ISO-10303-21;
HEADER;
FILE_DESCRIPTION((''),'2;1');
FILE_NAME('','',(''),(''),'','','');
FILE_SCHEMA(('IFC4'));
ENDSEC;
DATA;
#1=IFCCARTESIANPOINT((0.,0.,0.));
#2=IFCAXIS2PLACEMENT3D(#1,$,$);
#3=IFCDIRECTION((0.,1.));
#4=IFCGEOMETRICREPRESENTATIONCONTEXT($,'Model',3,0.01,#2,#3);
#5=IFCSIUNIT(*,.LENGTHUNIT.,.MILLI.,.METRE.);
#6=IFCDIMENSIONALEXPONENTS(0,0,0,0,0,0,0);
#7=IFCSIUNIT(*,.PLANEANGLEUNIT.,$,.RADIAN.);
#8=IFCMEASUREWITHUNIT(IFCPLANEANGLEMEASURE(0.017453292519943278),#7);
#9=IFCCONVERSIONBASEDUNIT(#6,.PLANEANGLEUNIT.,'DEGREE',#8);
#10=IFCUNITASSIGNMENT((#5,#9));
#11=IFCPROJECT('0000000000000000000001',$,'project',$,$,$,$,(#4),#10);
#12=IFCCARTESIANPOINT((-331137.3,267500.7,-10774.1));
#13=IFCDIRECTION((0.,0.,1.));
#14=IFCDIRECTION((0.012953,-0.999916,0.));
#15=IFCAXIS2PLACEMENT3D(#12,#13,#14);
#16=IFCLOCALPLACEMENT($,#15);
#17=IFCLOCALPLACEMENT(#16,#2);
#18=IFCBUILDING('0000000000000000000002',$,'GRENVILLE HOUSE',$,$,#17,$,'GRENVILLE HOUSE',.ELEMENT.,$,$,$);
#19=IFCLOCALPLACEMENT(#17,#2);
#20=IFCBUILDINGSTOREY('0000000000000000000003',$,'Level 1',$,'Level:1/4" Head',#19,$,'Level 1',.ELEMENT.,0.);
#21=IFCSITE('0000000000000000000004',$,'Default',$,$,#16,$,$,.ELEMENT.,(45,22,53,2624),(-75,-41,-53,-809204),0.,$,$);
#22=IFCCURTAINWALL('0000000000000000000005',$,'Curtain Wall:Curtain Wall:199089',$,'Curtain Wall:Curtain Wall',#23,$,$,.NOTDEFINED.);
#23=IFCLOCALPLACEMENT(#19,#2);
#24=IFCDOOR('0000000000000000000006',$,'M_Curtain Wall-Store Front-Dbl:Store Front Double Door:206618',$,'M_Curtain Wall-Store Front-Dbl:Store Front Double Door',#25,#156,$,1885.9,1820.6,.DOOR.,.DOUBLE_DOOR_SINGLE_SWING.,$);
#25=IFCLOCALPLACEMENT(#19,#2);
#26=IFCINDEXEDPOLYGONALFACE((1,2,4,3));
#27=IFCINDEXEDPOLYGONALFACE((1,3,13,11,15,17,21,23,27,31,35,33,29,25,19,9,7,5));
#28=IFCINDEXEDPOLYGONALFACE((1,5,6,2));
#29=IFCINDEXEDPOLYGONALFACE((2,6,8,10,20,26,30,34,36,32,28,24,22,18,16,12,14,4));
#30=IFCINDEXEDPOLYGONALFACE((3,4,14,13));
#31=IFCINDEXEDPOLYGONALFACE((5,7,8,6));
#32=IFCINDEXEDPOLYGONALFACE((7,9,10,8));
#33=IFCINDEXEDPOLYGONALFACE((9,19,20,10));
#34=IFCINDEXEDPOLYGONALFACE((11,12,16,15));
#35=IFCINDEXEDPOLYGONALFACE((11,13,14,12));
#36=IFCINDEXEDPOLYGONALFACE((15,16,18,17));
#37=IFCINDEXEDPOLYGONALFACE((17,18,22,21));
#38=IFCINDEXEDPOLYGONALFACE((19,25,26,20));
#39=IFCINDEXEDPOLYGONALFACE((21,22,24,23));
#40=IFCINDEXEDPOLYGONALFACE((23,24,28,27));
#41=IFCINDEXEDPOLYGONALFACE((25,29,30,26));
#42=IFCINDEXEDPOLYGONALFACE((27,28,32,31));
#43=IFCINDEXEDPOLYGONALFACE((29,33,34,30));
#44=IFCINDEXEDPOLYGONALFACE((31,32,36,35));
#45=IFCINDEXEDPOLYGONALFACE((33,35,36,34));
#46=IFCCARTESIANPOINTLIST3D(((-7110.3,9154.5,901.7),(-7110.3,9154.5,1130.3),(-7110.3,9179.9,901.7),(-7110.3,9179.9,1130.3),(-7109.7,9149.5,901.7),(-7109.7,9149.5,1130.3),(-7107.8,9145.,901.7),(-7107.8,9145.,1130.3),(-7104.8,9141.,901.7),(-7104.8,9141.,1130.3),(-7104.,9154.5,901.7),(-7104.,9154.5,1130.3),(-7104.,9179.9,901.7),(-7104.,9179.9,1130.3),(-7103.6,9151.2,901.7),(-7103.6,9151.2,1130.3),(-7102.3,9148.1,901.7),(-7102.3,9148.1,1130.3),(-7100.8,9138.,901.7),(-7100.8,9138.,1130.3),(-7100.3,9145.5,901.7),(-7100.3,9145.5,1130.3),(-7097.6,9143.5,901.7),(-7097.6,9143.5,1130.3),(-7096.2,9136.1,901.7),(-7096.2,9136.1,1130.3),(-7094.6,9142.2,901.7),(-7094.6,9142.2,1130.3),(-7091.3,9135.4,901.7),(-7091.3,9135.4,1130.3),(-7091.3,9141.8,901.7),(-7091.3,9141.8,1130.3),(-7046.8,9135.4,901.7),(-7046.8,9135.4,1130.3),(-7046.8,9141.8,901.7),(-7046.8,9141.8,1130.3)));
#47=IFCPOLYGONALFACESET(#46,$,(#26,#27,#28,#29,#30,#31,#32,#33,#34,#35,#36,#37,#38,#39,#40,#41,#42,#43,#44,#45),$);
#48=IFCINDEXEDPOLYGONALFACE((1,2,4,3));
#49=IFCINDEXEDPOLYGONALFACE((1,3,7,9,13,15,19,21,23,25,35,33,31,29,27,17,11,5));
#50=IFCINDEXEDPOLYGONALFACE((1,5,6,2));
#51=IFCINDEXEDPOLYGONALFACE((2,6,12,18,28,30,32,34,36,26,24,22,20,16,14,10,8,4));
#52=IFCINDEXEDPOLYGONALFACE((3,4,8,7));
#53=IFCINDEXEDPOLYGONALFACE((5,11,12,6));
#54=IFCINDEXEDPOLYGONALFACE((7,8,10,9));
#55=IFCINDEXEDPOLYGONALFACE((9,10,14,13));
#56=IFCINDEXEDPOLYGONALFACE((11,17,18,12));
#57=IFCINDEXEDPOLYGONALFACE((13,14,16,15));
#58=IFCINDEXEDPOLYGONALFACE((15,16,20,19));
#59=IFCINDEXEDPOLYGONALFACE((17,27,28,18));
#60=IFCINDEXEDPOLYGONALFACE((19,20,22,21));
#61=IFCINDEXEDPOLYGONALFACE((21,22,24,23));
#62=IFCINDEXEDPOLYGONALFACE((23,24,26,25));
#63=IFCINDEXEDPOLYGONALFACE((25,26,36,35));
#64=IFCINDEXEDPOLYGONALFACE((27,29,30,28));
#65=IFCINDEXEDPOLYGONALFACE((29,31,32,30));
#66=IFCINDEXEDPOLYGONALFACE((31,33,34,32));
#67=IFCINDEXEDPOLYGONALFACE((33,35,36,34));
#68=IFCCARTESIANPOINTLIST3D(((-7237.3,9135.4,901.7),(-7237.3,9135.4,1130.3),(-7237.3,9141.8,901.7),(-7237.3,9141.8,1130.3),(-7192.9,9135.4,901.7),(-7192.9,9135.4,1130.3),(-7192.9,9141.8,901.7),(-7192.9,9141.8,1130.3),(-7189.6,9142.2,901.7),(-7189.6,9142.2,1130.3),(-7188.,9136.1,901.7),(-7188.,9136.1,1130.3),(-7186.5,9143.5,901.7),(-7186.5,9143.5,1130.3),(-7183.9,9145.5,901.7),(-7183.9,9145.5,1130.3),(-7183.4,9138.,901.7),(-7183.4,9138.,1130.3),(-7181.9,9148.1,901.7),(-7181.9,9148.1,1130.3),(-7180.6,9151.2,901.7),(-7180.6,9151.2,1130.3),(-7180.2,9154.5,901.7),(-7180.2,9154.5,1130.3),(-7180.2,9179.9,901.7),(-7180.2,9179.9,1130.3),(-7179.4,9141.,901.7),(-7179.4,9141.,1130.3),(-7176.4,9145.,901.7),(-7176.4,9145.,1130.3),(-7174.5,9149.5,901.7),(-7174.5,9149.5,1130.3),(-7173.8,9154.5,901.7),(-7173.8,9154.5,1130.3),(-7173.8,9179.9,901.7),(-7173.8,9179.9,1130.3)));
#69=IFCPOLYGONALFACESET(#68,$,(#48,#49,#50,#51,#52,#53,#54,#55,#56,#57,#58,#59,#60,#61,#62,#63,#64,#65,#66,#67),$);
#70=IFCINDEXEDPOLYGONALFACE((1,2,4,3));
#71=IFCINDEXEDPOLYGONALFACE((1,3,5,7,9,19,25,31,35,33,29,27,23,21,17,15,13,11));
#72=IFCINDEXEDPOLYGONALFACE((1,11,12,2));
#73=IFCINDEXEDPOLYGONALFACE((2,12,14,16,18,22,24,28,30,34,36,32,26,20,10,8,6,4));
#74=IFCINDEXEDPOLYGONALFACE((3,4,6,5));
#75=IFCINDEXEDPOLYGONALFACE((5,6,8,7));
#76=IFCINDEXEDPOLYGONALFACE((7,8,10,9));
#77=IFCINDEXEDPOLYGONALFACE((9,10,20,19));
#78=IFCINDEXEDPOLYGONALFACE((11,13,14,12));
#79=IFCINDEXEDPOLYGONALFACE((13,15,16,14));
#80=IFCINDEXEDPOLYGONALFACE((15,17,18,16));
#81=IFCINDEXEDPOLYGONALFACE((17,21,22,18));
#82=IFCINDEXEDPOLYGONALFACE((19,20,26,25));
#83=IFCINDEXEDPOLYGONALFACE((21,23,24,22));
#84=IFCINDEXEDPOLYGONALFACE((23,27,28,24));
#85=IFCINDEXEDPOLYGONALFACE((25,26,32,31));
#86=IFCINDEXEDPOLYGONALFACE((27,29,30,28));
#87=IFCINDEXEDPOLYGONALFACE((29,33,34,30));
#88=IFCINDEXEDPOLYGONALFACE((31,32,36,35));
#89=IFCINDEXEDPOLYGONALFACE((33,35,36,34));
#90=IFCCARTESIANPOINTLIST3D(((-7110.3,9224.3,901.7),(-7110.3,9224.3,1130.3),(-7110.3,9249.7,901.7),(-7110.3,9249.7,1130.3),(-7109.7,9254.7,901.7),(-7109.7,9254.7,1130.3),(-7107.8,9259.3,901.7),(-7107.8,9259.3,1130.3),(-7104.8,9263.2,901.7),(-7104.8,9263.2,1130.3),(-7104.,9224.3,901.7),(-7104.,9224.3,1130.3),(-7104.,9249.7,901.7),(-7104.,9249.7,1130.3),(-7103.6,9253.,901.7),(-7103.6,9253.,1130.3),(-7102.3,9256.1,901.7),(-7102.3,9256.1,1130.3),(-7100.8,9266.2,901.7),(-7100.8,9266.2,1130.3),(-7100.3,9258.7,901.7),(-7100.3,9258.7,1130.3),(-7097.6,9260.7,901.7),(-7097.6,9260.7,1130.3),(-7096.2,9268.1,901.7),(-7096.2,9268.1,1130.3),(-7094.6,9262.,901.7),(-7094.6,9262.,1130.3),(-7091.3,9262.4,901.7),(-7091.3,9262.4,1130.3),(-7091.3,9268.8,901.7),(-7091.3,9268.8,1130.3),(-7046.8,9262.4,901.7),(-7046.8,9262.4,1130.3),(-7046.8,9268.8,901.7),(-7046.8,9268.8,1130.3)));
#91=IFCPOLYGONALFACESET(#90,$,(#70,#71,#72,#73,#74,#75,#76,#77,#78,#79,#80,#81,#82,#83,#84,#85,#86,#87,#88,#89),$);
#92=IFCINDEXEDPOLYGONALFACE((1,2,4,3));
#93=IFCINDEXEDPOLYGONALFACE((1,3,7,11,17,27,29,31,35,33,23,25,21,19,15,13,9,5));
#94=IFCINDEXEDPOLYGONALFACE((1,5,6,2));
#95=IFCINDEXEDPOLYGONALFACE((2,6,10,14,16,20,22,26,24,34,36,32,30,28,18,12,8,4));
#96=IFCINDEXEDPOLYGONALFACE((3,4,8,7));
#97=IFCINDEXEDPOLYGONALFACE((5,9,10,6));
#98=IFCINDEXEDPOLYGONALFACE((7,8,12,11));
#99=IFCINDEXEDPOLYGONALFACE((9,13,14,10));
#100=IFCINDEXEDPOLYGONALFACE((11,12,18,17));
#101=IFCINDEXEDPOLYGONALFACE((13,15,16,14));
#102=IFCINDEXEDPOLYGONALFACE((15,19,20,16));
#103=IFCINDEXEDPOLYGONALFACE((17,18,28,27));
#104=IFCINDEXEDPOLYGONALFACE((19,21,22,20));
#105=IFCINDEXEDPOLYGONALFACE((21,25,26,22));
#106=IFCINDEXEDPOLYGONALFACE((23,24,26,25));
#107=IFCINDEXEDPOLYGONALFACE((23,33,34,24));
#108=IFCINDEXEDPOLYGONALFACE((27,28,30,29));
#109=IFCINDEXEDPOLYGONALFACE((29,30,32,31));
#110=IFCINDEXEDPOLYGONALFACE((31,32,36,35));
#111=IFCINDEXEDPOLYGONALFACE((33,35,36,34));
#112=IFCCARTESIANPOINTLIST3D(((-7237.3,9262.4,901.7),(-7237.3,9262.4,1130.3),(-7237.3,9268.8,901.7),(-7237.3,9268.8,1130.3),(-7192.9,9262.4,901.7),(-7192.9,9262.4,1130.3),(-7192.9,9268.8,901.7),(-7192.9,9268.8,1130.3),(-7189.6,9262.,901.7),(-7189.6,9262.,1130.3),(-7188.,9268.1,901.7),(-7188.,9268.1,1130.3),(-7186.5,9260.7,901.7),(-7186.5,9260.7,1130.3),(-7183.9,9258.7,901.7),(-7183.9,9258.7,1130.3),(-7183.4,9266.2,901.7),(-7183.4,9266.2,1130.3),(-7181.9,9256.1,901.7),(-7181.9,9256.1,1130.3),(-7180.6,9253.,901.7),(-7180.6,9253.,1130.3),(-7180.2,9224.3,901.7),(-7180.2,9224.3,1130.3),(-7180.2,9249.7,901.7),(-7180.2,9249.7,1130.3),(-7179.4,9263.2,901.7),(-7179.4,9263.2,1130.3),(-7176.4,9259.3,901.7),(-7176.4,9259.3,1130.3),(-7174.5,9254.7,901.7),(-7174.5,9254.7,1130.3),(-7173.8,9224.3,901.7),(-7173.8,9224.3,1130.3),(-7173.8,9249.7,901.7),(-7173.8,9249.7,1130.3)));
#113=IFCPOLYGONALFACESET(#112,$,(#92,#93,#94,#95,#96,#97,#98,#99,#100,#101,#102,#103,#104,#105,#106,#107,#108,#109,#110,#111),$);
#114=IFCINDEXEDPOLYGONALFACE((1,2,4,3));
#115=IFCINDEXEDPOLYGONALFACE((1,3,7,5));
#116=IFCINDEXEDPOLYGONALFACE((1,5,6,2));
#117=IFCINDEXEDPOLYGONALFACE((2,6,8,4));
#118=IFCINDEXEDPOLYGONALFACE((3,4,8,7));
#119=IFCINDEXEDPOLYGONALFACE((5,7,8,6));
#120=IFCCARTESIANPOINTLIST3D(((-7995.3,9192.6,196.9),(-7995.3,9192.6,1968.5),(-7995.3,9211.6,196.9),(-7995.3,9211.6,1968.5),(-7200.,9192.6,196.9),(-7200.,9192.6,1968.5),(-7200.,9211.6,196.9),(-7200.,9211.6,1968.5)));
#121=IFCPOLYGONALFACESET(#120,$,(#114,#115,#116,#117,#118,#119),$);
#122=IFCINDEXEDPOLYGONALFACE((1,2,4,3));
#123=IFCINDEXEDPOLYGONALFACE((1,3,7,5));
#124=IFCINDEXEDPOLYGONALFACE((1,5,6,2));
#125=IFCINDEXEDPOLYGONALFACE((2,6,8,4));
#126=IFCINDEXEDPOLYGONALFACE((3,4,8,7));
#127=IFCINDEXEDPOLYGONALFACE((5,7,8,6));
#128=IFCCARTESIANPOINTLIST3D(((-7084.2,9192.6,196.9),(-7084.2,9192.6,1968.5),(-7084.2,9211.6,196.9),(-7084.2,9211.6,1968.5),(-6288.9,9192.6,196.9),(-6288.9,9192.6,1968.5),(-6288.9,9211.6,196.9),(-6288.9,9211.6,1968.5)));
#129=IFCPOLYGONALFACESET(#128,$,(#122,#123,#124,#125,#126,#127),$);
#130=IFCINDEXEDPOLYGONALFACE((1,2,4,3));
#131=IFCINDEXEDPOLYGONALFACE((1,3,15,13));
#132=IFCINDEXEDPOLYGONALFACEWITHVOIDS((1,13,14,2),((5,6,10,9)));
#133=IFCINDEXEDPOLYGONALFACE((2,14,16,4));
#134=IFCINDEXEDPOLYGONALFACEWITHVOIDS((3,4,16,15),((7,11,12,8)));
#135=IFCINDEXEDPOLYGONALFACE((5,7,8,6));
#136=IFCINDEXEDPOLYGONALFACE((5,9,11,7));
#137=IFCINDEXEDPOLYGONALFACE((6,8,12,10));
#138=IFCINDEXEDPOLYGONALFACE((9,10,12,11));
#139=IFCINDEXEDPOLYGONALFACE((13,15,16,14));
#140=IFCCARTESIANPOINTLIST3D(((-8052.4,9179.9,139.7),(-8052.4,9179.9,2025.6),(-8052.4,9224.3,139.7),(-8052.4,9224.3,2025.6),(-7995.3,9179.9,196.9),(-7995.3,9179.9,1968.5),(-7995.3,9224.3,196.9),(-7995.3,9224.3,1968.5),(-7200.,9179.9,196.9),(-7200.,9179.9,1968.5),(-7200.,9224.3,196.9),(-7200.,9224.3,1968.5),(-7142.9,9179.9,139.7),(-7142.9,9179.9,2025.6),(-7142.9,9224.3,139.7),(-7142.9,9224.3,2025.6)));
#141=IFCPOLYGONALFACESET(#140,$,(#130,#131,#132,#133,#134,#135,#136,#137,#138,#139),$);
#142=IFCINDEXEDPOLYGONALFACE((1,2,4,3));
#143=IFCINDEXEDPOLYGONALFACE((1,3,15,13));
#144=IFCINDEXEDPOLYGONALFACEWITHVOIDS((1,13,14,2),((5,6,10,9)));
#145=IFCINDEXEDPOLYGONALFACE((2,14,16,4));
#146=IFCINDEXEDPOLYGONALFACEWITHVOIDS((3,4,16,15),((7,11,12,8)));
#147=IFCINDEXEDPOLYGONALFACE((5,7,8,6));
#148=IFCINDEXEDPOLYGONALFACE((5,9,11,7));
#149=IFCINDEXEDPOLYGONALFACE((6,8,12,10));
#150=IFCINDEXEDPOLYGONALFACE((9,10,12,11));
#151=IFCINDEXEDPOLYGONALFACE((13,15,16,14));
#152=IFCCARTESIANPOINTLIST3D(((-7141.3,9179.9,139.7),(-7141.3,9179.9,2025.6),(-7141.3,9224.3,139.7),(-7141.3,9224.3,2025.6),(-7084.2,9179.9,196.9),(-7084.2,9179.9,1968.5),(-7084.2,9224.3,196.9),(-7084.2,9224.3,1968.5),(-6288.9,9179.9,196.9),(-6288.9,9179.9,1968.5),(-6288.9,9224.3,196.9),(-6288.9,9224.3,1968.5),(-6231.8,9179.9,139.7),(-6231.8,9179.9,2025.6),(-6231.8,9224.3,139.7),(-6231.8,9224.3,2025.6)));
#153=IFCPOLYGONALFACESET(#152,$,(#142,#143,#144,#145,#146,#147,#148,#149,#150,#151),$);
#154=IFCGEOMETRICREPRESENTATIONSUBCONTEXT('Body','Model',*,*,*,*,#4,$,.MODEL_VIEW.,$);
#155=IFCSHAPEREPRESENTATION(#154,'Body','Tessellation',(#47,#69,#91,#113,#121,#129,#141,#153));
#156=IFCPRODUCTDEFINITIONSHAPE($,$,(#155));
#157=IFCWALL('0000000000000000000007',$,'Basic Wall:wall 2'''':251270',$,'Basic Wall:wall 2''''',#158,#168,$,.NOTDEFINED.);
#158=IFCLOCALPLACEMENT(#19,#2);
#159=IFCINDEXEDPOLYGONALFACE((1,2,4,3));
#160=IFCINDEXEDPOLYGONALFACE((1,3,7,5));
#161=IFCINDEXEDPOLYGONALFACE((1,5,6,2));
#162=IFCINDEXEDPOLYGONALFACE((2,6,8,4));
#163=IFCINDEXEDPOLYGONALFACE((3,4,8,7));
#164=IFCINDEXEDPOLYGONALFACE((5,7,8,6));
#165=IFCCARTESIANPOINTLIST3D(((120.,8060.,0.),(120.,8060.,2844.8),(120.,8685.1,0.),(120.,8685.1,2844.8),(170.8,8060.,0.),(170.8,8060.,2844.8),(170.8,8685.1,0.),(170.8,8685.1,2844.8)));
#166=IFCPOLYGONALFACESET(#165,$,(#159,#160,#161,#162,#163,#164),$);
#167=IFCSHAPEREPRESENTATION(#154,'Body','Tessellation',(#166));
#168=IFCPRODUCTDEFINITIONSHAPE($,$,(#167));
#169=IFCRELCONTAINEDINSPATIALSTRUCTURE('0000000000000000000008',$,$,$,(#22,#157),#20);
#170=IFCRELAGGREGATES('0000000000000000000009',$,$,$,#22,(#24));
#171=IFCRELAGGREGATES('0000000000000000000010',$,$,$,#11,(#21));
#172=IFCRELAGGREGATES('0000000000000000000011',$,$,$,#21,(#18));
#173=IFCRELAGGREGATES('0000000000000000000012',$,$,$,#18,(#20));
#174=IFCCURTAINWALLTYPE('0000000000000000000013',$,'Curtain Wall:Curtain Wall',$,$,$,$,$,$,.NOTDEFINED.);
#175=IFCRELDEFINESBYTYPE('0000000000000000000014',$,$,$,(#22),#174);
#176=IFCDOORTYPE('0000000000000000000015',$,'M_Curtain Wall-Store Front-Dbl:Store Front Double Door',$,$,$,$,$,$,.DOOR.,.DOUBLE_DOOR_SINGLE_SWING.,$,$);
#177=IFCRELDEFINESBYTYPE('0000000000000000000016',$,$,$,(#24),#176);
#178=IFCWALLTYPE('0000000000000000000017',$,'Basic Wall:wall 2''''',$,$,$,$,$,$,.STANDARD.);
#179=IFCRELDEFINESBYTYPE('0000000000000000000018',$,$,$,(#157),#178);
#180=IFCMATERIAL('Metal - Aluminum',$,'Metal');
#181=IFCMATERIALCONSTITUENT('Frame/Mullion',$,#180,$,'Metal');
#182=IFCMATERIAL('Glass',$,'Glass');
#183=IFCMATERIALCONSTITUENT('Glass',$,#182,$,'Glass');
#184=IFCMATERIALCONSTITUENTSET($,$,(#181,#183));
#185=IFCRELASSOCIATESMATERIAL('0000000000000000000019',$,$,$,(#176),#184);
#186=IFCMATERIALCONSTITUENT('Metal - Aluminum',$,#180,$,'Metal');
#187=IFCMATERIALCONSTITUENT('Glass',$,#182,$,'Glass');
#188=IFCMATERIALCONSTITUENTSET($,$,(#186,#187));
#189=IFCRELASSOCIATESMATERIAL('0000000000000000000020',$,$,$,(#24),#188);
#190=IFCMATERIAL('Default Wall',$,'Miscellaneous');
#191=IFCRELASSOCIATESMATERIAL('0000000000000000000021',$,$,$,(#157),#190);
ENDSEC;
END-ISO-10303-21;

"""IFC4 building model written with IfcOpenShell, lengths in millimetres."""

from ifc_helpers import new_model, entity, si_unit, converted_unit, direction, frame, origin, place, context, subcontext, project, spatial, line, arc, indexed_curve, outline, extrude, source, transform, mapped, material, constituent, constituent_set, type_object, type_shapes, element, aggregate, save


model = new_model("IFC4")

# Units and contexts
model_context = context("Model", 3, precision=0.01, world=origin(), true_north=direction((0.0, 1.0)))
body_context = subcontext(model_context, "Body", "Model", "MODEL_VIEW")
ifc_project = project(units=[si_unit("LENGTHUNIT", "METRE", prefix="MILLI"), converted_unit("PLANEANGLEUNIT", "DEGREE", entity("IfcPlaneAngleMeasure", 0.017453292519943278), si_unit("PLANEANGLEUNIT", "RADIAN"), dimensions=[0, 0, 0, 0, 0, 0, 0])], contexts=[model_context])

# Site, building, storey
site_placement = place(None, frame((-331137.3, 267500.7, -10774.1), z_axis=(0.0, 0.0, 1.0), x_axis=(0.012953, -0.999916, 0.0)))
site = spatial("IfcSite", under=ifc_project, at=site_placement, Name="Default", CompositionType="ELEMENT", RefLatitude=(45, 22, 53, 2624), RefLongitude=(-75, -41, -53, -809204), RefElevation=0.0)
building_placement = place(site_placement, origin())
building = spatial("IfcBuilding", under=site, at=building_placement, Name="GRENVILLE HOUSE", LongName="GRENVILLE HOUSE", CompositionType="ELEMENT")
storey_placement = place(building_placement, origin())
storey = spatial("IfcBuildingStorey", under=building, at=storey_placement, Name="Level 1", ObjectType="Level:1/4\" Head", LongName="Level 1", CompositionType="ELEMENT", Elevation=0.0)

# Shared definitions
curtain_wall_type = type_object("IfcCurtainWallType", Name="Curtain Wall:Curtain Wall", PredefinedType="NOTDEFINED")

# Curtain wall
curtain_wall_1_placement = place(storey_placement, origin())
curtain_wall_1 = element("IfcCurtainWall", 1, at=curtain_wall_1_placement, inside=storey, type_object=curtain_wall_type, Name="Curtain Wall:Curtain Wall:199089", ObjectType="Curtain Wall:Curtain Wall", PredefinedType="NOTDEFINED")
ifc_material_1 = material(Name="Glass", Category="Glass")

# Shared definitions
ifc_material_2 = material(Name="Default Wall", Category="Miscellaneous")

# Door
ifc_material_3 = material(Name="Metal - Aluminum", Category="Metal")
ifc_constituent_1 = constituent(ifc_material_3, Name="Metal - Aluminum", Category="Metal")
ifc_constituent_2 = constituent(ifc_material_1, Name="Glass", Category="Glass")
ifc_constituent_set_1 = constituent_set(constituents=[ifc_constituent_1, ifc_constituent_2])
ifc_constituent_3 = constituent(ifc_material_3, Name="Frame/Mullion", Category="Metal")
ifc_constituent_4 = constituent(ifc_material_1, Name="Glass", Category="Glass")
ifc_constituent_set_2 = constituent_set(constituents=[ifc_constituent_3, ifc_constituent_4])
door_type = type_object("IfcDoorType", Name="M_Curtain Wall-Store Front-Dbl:Store Front Double Door", OperationType="DOUBLE_DOOR_SINGLE_SWING", PredefinedType="DOOR", material=ifc_constituent_set_2)
shared_shape_1 = source(origin(), body_context, "Body", "SweptSolid", [
    extrude(outline(indexed_curve([(-22.2, 1.6), (-16.6, -11.9), (-3.2, -17.5), (41.3, -17.5), (41.3, -11.1), (-3.2, -11.1), (-12.2, -7.4), (-15.9, 1.6), (-15.9, 27.0), (-22.2, 27.0)], segments=[arc(1, 2, 3), line(3, 4, 5, 6), arc(6, 7, 8), line(8, 9, 10, 1)], self_intersect=False)), frame((54.0, -16.4, 762.0)), (0.0, 0.0, 1.0), 228.6),
    extrude(outline(indexed_curve([(1.6, -22.2), (27.0, -22.2), (27.0, -15.9), (1.6, -15.9), (-7.4, -12.2), (-11.1, -3.2), (-11.1, 41.3), (-17.5, 41.3), (-17.5, -3.2), (-11.9, -16.6)], segments=[line(1, 2, 3, 4), arc(4, 5, 6), line(6, 7, 8, 9), arc(9, 10, 1)], self_intersect=False)), frame((-54.0, -16.4, 762.0), z_axis=(0.0, 0.0, 1.0), x_axis=(0.0, 1.0, 0.0)), (0.0, 0.0, 1.0), 228.6),
    extrude(outline(indexed_curve([(1.6, -22.2), (27.0, -22.2), (27.0, -15.9), (1.6, -15.9), (-7.4, -12.2), (-11.1, -3.2), (-11.1, 41.3), (-17.5, 41.3), (-17.5, -3.2), (-11.9, -16.6)], segments=[line(1, 2, 3, 4), arc(4, 5, 6), line(6, 7, 8, 9), arc(9, 10, 1)], self_intersect=False)), frame((54.0, 82.0, 762.0), z_axis=(0.0, 0.0, 1.0), x_axis=(0.0, -1.0, 0.0)), (0.0, 0.0, 1.0), 228.6),
    extrude(outline(indexed_curve([(22.2, -1.6), (16.6, 11.9), (3.2, 17.5), (-41.3, 17.5), (-41.3, 11.1), (3.2, 11.1), (12.2, 7.4), (15.9, -1.6), (15.9, -27.0), (22.2, -27.0)], segments=[arc(1, 2, 3), line(3, 4, 5, 6), arc(6, 7, 8), line(8, 9, 10, 1)], self_intersect=False)), frame((-54.0, 82.0, 762.0)), (0.0, 0.0, 1.0), 228.6),
    extrude(outline(indexed_curve([(-9.5, -397.6), (9.5, -397.6), (9.5, 397.6), (-9.5, 397.6), (-9.5, -397.6)], self_intersect=False)), frame((-455.6, 32.8, 57.2), z_axis=(0.0, 0.0, 1.0), x_axis=(0.0, 1.0, 0.0)), (0.0, 0.0, 1.0), 1771.6),
    extrude(outline(indexed_curve([(-9.5, -397.6), (9.5, -397.6), (9.5, 397.6), (-9.5, 397.6), (-9.5, -397.6)], self_intersect=False)), frame((455.6, 32.8, 57.2), z_axis=(0.0, 0.0, 1.0), x_axis=(0.0, 1.0, 0.0)), (0.0, 0.0, 1.0), 1771.6),
    extrude(outline(indexed_curve([(-943.0, -454.8), (943.0, -454.8), (943.0, 454.8), (-943.0, 454.8), (-943.0, -454.8)], self_intersect=False), holes=[indexed_curve([(-885.8, 397.6), (885.8, 397.6), (885.8, -397.6), (-885.8, -397.6), (-885.8, 397.6)], self_intersect=False)]), frame((-455.6, 10.5, 943.0), z_axis=(0.0, 1.0, 0.0), x_axis=(0.0, 0.0, -1.0)), (0.0, 0.0, 1.0), 44.5),
    extrude(outline(indexed_curve([(-454.8, -943.0), (454.8, -943.0), (454.8, 943.0), (-454.8, 943.0), (-454.8, -943.0)], self_intersect=False), holes=[indexed_curve([(-397.6, -885.8), (-397.6, 885.8), (397.6, 885.8), (397.6, -885.8), (-397.6, -885.8)], self_intersect=False)]), frame((455.6, 10.5, 943.0), z_axis=(0.0, 1.0, 0.0), x_axis=(1.0, 0.0, 0.0)), (0.0, 0.0, 1.0), 44.5),
])
type_shapes(door_type, [shared_shape_1])
door_placement = place(curtain_wall_1_placement, frame((-7142.1, 9169.3, 139.7)))
door = element("IfcDoor", 2, at=door_placement, type_object=door_type, material=ifc_constituent_set_1, Name="M_Curtain Wall-Store Front-Dbl:Store Front Double Door:206618", ObjectType="M_Curtain Wall-Store Front-Dbl:Store Front Double Door", OperationType="DOUBLE_DOOR_SINGLE_SWING", OverallHeight=1885.9, OverallWidth=1820.6, PredefinedType="DOOR", context=body_context, shape_type="MappedRepresentation", body=[
    mapped(shared_shape_1, transform((0.0, 0.0, 0.0), scale=1.0)),
])
aggregate(curtain_wall_1, [door])

# Wall
wall_type_1 = type_object("IfcWallType", Name="Basic Wall:wall 2''", PredefinedType="STANDARD")
wall_1_placement = place(storey_placement, frame((145.4, 8060.0, 0.0), z_axis=(0.0, 0.0, 1.0), x_axis=(0.0, 1.0, 0.0)))
element("IfcWall", 3, at=wall_1_placement, inside=storey, type_object=wall_type_1, material=ifc_material_2, Name="Basic Wall:wall 2'':251270", ObjectType="Basic Wall:wall 2''", PredefinedType="NOTDEFINED", context=body_context, shape_type="SweptSolid", body=[
    extrude(outline(indexed_curve([(625.2, 25.4), (0.0, 25.4), (0.0, -25.4), (625.2, -25.4), (625.2, 25.4)], self_intersect=False)), origin(), (0.0, 0.0, 1.0), 2844.8),
])

save(model, "model.ifc")
